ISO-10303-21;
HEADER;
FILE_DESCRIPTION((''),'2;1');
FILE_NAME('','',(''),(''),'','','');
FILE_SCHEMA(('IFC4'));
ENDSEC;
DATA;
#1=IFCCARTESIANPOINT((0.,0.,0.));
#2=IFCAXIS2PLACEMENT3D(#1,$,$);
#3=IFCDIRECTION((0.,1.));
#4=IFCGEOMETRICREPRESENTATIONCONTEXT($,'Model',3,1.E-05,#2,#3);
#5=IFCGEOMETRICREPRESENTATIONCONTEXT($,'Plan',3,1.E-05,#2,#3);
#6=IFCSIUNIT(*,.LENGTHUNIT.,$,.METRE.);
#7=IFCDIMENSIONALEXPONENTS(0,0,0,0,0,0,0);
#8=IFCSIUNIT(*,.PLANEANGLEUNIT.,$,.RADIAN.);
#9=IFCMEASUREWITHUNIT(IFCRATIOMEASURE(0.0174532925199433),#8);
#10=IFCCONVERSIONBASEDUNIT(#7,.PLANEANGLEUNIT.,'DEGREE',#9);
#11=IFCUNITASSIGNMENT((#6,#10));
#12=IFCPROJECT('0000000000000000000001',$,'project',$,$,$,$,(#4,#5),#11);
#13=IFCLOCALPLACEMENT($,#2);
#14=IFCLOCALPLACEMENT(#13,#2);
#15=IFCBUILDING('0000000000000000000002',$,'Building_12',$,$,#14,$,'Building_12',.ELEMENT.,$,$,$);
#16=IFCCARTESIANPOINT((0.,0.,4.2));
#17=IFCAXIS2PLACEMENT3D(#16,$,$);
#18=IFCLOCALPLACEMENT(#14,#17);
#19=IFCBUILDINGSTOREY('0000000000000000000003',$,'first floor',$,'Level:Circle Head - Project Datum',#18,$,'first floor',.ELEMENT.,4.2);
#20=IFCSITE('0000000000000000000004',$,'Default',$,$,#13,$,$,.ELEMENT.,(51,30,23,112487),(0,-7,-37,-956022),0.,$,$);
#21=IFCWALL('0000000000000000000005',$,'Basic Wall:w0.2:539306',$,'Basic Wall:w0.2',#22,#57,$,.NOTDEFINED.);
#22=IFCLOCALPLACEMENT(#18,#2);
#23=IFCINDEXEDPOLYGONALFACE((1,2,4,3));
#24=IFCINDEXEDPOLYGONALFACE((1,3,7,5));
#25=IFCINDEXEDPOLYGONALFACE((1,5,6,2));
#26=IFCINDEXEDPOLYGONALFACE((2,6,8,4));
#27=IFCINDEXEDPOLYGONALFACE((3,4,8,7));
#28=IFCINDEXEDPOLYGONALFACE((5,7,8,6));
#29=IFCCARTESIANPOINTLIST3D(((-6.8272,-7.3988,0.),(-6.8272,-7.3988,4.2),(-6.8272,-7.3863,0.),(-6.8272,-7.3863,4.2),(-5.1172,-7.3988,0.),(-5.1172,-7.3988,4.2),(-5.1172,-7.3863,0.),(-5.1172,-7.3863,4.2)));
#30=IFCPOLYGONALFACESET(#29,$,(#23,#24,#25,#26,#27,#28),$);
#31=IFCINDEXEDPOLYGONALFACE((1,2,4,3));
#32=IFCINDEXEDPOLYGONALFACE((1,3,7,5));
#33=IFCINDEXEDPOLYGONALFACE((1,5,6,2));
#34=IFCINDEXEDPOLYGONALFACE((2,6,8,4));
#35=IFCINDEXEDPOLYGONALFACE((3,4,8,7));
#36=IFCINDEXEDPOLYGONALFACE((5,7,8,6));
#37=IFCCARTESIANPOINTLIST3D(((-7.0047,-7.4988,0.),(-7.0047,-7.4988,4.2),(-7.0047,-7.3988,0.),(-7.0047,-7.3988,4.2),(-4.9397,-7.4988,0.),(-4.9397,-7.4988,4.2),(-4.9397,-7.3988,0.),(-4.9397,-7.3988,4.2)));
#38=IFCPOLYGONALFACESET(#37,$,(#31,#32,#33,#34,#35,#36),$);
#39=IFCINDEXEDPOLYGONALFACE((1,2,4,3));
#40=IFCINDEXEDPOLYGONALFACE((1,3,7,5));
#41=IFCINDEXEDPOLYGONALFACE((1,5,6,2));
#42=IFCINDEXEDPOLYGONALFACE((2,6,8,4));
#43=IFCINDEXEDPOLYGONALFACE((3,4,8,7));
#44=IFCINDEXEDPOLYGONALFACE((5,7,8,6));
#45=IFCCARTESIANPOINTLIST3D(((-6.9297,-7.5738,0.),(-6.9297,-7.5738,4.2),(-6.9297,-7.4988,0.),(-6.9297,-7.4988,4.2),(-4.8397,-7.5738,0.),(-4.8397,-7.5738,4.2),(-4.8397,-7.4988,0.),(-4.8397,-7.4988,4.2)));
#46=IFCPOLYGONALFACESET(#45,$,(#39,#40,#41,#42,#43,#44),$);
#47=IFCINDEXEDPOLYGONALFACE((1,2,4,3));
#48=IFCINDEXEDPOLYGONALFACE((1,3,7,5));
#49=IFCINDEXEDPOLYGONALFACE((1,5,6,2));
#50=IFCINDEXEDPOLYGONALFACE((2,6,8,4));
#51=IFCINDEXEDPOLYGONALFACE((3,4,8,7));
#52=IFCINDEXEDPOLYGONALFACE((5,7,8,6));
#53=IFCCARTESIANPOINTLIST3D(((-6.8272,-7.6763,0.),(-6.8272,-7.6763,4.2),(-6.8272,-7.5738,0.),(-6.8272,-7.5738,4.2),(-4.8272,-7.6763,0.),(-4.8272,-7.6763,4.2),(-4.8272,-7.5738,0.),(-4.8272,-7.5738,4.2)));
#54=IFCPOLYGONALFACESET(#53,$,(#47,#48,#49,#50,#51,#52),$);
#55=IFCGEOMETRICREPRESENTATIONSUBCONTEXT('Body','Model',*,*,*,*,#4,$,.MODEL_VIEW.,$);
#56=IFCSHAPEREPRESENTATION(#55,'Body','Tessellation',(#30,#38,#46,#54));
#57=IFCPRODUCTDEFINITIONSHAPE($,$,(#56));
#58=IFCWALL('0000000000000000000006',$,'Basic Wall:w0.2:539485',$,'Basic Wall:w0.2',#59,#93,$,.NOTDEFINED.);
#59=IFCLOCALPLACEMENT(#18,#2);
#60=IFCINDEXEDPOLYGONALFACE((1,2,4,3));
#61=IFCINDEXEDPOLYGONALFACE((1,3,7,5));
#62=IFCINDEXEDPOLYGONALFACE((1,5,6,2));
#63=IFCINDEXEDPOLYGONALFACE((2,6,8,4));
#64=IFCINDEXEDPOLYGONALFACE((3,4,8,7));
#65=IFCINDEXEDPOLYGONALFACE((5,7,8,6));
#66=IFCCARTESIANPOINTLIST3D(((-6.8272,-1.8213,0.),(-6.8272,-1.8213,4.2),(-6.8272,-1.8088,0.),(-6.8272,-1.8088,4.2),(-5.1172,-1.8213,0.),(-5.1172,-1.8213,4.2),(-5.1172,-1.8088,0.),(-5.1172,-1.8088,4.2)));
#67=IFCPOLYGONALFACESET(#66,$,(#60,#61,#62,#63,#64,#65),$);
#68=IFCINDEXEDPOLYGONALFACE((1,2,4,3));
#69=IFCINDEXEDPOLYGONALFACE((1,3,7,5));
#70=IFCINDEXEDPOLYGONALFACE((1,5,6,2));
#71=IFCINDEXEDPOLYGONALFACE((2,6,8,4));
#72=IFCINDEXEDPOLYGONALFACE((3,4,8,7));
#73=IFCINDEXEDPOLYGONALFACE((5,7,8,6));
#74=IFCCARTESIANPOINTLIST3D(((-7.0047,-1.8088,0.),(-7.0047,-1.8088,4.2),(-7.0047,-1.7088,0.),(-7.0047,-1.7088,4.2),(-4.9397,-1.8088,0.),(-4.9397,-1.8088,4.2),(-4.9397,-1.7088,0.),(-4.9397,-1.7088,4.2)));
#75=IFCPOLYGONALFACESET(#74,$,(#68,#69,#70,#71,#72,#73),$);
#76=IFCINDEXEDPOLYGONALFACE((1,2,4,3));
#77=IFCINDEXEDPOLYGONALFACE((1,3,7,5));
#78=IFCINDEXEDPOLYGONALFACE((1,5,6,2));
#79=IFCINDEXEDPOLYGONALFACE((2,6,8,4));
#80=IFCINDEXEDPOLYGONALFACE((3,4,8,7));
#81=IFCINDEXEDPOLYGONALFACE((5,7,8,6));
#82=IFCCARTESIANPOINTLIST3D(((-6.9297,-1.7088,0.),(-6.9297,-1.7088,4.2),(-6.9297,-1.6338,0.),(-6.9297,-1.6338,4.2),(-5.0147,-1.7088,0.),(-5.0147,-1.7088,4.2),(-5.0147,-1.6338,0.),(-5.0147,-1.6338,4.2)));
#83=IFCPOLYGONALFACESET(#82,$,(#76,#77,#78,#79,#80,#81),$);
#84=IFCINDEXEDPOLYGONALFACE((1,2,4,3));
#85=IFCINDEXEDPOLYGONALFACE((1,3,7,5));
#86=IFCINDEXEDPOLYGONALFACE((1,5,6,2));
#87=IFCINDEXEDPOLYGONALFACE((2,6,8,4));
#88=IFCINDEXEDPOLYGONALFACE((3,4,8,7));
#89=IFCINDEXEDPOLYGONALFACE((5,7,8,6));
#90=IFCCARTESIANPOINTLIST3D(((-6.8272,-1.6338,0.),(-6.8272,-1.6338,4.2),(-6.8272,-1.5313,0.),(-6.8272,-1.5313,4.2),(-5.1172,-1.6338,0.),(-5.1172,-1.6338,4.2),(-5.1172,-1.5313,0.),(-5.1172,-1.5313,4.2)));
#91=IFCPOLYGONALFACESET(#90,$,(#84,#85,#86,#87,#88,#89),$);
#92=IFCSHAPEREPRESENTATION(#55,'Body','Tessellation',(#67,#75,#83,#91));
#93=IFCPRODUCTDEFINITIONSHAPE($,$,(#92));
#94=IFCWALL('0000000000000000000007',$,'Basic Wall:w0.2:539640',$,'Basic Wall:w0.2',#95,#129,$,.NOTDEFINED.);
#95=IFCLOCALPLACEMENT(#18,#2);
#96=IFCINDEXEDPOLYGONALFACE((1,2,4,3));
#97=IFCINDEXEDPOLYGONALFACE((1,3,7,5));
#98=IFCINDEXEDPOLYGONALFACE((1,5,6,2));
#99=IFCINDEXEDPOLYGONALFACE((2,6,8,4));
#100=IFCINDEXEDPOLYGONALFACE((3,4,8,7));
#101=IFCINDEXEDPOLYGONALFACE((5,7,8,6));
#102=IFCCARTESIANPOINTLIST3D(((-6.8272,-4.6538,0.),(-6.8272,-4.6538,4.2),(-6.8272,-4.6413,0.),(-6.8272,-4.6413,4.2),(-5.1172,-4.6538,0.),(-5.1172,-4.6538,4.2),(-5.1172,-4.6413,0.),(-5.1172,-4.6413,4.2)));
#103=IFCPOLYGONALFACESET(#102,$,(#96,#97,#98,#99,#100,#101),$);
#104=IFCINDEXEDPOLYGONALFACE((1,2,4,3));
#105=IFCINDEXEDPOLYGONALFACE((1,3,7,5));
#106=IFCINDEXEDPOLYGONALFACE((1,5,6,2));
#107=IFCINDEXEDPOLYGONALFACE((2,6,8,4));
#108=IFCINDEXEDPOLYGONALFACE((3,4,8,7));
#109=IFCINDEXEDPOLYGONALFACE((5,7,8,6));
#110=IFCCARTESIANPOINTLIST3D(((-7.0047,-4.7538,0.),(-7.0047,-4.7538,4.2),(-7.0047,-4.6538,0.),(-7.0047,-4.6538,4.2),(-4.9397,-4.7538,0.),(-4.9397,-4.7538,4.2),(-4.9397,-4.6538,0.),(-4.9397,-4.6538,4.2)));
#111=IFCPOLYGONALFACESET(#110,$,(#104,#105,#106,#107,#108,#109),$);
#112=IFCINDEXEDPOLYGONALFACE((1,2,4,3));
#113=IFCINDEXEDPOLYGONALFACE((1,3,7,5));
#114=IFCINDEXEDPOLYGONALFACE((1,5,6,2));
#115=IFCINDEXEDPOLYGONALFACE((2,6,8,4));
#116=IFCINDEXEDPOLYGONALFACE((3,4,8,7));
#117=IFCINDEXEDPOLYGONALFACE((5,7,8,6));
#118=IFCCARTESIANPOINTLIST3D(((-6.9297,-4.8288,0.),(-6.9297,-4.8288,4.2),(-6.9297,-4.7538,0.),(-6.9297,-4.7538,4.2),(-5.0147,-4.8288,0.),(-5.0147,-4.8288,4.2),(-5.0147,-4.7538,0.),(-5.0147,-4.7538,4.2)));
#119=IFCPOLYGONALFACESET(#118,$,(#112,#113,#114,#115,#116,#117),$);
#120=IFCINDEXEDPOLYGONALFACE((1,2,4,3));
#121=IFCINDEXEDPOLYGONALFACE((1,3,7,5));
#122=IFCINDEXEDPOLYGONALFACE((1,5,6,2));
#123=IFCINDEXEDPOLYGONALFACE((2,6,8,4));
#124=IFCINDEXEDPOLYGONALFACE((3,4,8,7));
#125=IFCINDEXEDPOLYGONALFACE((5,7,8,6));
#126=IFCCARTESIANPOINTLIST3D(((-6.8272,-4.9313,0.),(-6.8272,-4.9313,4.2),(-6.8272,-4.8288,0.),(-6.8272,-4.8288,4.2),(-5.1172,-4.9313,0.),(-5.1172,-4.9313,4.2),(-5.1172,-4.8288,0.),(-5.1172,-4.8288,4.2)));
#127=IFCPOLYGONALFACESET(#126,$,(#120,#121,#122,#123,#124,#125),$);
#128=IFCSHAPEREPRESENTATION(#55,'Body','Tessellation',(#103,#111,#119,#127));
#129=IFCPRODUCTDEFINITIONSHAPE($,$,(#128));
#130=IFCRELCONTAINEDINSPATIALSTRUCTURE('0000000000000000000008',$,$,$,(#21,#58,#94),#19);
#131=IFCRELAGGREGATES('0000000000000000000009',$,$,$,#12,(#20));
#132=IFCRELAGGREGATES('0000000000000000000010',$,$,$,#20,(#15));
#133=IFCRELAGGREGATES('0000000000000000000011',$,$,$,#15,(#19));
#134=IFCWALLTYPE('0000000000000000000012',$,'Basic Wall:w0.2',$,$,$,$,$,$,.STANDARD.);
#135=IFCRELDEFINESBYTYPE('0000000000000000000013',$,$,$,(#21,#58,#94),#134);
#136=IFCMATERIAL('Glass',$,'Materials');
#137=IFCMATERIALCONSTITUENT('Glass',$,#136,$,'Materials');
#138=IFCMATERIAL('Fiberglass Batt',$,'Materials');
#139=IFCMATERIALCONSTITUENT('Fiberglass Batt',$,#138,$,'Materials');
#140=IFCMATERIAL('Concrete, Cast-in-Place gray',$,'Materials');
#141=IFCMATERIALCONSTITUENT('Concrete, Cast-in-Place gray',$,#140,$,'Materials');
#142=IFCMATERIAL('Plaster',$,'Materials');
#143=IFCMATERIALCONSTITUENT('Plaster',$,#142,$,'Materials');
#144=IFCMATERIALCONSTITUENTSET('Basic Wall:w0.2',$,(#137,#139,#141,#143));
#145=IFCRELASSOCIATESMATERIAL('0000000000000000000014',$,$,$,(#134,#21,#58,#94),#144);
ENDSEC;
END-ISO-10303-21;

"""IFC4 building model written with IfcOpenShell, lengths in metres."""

from ifc_helpers import new_model, entity, si_unit, converted_unit, direction, frame, origin, place, context, subcontext, project, spatial, indexed_curve, outline, extrude, material, constituent, constituent_set, type_object, element, save


model = new_model("IFC4")

# Units and contexts
model_context = context("Model", 3, precision=1e-05, world=origin(), true_north=direction((0.0, 1.0)))
plan_context = context("Plan", 3, precision=1e-05, world=origin(), true_north=direction((0.0, 1.0)))
body_context = subcontext(model_context, "Body", "Model", "MODEL_VIEW")
ifc_project = project(units=[si_unit("LENGTHUNIT", "METRE"), converted_unit("PLANEANGLEUNIT", "DEGREE", entity("IfcRatioMeasure", 0.0174532925199433), si_unit("PLANEANGLEUNIT", "RADIAN"), dimensions=[0, 0, 0, 0, 0, 0, 0])], contexts=[model_context, plan_context])

# Site, building, storey
site_placement = place(None, origin())
site = spatial("IfcSite", under=ifc_project, at=site_placement, Name="Default", CompositionType="ELEMENT", RefLatitude=(51, 30, 23, 112487), RefLongitude=(0, -7, -37, -956022), RefElevation=0.0)
building_placement = place(site_placement, origin())
building = spatial("IfcBuilding", under=site, at=building_placement, Name="Building_12", LongName="Building_12", CompositionType="ELEMENT")
storey_placement = place(building_placement, frame((0.0, 0.0, 4.2)))
storey = spatial("IfcBuildingStorey", under=building, at=storey_placement, Name="first floor", ObjectType="Level:Circle Head - Project Datum", LongName="first floor", CompositionType="ELEMENT", Elevation=4.2)

# Shared definitions
ifc_material_1 = material(Name="Plaster", Category="Materials")
ifc_material_2 = material(Name="Glass", Category="Materials")

# Shared definitions
ifc_constituent_1 = constituent(ifc_material_2, Name="Glass", Category="Materials")
ifc_material_3 = material(Name="Fiberglass Batt", Category="Materials")
ifc_constituent_2 = constituent(ifc_material_3, Name="Fiberglass Batt", Category="Materials")
ifc_material_4 = material(Name="Concrete, Cast-in-Place gray", Category="Materials")
ifc_constituent_3 = constituent(ifc_material_4, Name="Concrete, Cast-in-Place gray", Category="Materials")
ifc_constituent_4 = constituent(ifc_material_1, Name="Plaster", Category="Materials")
ifc_constituent_set_1 = constituent_set(constituents=[ifc_constituent_1, ifc_constituent_2, ifc_constituent_3, ifc_constituent_4], Name="Basic Wall:w0.2")
wall_type_1 = type_object("IfcWallType", Name="Basic Wall:w0.2", PredefinedType="STANDARD", material=ifc_constituent_set_1)

# Walls
wall_1_placement = place(storey_placement, frame((-5.1172, -7.5313, 0.0), z_axis=(0.0, 0.0, 1.0), x_axis=(-1.0, 0.0, 0.0)))
element("IfcWall", 1, at=wall_1_placement, inside=storey, type_object=wall_type_1, material=ifc_constituent_set_1, Name="Basic Wall:w0.2:539306", ObjectType="Basic Wall:w0.2", PredefinedType="NOTDEFINED", context=body_context, shape_type="SweptSolid", body=[
    extrude(outline(indexed_curve([(-0.0063, -0.855), (0.0062, -0.855), (0.0063, 0.855), (-0.0062, 0.855), (-0.0063, -0.855)], self_intersect=False)), frame((0.855, -0.1388, 0.0), z_axis=(0.0, 0.0, 1.0), x_axis=(0.0, 1.0, 0.0)), (0.0, 0.0, 1.0), 4.2),
    extrude(outline(indexed_curve([(-1.0325, -0.05), (1.0325, -0.05), (1.0325, 0.05), (-1.0325, 0.05), (-1.0325, -0.05)], self_intersect=False)), frame((0.855, -0.0825, 0.0)), (0.0, 0.0, 1.0), 4.2),
    extrude(outline(indexed_curve([(-1.045, -0.0375), (1.045, -0.0375), (1.045, 0.0375), (-1.045, 0.0375), (-1.045, -0.0375)], self_intersect=False)), frame((0.7675, 0.005, 0.0)), (0.0, 0.0, 1.0), 4.2),
    extrude(outline(indexed_curve([(-0.0513, -1.0), (0.0512, -1.0), (0.0513, 1.0), (-0.0512, 1.0), (-0.0513, -1.0)], self_intersect=False)), frame((0.71, 0.0937, 0.0), z_axis=(0.0, 0.0, 1.0), x_axis=(0.0, -1.0, 0.0)), (0.0, 0.0, 1.0), 4.2),
])
wall_2_placement = place(storey_placement, frame((-6.8272, -1.6763, 0.0)))
element("IfcWall", 2, at=wall_2_placement, inside=storey, type_object=wall_type_1, material=ifc_constituent_set_1, Name="Basic Wall:w0.2:539485", ObjectType="Basic Wall:w0.2", PredefinedType="NOTDEFINED", context=body_context, shape_type="SweptSolid", body=[
    extrude(outline(indexed_curve([(-0.0063, -0.855), (0.0062, -0.855), (0.0063, 0.855), (-0.0062, 0.855), (-0.0063, -0.855)], self_intersect=False)), frame((0.855, -0.1388, 0.0), z_axis=(0.0, 0.0, 1.0), x_axis=(0.0, 1.0, 0.0)), (0.0, 0.0, 1.0), 4.2),
    extrude(outline(indexed_curve([(-1.0325, -0.05), (1.0325, -0.05), (1.0325, 0.05), (-1.0325, 0.05), (-1.0325, -0.05)], self_intersect=False)), frame((0.855, -0.0825, 0.0)), (0.0, 0.0, 1.0), 4.2),
    extrude(outline(indexed_curve([(-0.9575, -0.0375), (0.9575, -0.0375), (0.9575, 0.0375), (-0.9575, 0.0375), (-0.9575, -0.0375)], self_intersect=False)), frame((0.855, 0.005, 0.0)), (0.0, 0.0, 1.0), 4.2),
    extrude(outline(indexed_curve([(-0.0513, -0.855), (0.0512, -0.855), (0.0513, 0.855), (-0.0512, 0.855), (-0.0513, -0.855)], self_intersect=False)), frame((0.855, 0.0938, 0.0), z_axis=(0.0, 0.0, 1.0), x_axis=(0.0, -1.0, 0.0)), (0.0, 0.0, 1.0), 4.2),
])
wall_3_placement = place(storey_placement, frame((-5.1172, -4.7863, 0.0), z_axis=(0.0, 0.0, 1.0), x_axis=(-1.0, 0.0, 0.0)))
element("IfcWall", 3, at=wall_3_placement, inside=storey, type_object=wall_type_1, material=ifc_constituent_set_1, Name="Basic Wall:w0.2:539640", ObjectType="Basic Wall:w0.2", PredefinedType="NOTDEFINED", context=body_context, shape_type="SweptSolid", body=[
    extrude(outline(indexed_curve([(-0.0063, -0.855), (0.0062, -0.855), (0.0063, 0.855), (-0.0062, 0.855), (-0.0063, -0.855)], self_intersect=False)), frame((0.855, -0.1388, 0.0), z_axis=(0.0, 0.0, 1.0), x_axis=(0.0, 1.0, 0.0)), (0.0, 0.0, 1.0), 4.2),
    extrude(outline(indexed_curve([(-1.0325, -0.05), (1.0325, -0.05), (1.0325, 0.05), (-1.0325, 0.05), (-1.0325, -0.05)], self_intersect=False)), frame((0.855, -0.0825, 0.0)), (0.0, 0.0, 1.0), 4.2),
    extrude(outline(indexed_curve([(-0.9575, -0.0375), (0.9575, -0.0375), (0.9575, 0.0375), (-0.9575, 0.0375), (-0.9575, -0.0375)], self_intersect=False)), frame((0.855, 0.005, 0.0)), (0.0, 0.0, 1.0), 4.2),
    extrude(outline(indexed_curve([(-0.0513, -0.855), (0.0512, -0.855), (0.0513, 0.855), (-0.0512, 0.855), (-0.0513, -0.855)], self_intersect=False)), frame((0.855, 0.0937, 0.0), z_axis=(0.0, 0.0, 1.0), x_axis=(0.0, -1.0, 0.0)), (0.0, 0.0, 1.0), 4.2),
])

save(model, "model.ifc")
